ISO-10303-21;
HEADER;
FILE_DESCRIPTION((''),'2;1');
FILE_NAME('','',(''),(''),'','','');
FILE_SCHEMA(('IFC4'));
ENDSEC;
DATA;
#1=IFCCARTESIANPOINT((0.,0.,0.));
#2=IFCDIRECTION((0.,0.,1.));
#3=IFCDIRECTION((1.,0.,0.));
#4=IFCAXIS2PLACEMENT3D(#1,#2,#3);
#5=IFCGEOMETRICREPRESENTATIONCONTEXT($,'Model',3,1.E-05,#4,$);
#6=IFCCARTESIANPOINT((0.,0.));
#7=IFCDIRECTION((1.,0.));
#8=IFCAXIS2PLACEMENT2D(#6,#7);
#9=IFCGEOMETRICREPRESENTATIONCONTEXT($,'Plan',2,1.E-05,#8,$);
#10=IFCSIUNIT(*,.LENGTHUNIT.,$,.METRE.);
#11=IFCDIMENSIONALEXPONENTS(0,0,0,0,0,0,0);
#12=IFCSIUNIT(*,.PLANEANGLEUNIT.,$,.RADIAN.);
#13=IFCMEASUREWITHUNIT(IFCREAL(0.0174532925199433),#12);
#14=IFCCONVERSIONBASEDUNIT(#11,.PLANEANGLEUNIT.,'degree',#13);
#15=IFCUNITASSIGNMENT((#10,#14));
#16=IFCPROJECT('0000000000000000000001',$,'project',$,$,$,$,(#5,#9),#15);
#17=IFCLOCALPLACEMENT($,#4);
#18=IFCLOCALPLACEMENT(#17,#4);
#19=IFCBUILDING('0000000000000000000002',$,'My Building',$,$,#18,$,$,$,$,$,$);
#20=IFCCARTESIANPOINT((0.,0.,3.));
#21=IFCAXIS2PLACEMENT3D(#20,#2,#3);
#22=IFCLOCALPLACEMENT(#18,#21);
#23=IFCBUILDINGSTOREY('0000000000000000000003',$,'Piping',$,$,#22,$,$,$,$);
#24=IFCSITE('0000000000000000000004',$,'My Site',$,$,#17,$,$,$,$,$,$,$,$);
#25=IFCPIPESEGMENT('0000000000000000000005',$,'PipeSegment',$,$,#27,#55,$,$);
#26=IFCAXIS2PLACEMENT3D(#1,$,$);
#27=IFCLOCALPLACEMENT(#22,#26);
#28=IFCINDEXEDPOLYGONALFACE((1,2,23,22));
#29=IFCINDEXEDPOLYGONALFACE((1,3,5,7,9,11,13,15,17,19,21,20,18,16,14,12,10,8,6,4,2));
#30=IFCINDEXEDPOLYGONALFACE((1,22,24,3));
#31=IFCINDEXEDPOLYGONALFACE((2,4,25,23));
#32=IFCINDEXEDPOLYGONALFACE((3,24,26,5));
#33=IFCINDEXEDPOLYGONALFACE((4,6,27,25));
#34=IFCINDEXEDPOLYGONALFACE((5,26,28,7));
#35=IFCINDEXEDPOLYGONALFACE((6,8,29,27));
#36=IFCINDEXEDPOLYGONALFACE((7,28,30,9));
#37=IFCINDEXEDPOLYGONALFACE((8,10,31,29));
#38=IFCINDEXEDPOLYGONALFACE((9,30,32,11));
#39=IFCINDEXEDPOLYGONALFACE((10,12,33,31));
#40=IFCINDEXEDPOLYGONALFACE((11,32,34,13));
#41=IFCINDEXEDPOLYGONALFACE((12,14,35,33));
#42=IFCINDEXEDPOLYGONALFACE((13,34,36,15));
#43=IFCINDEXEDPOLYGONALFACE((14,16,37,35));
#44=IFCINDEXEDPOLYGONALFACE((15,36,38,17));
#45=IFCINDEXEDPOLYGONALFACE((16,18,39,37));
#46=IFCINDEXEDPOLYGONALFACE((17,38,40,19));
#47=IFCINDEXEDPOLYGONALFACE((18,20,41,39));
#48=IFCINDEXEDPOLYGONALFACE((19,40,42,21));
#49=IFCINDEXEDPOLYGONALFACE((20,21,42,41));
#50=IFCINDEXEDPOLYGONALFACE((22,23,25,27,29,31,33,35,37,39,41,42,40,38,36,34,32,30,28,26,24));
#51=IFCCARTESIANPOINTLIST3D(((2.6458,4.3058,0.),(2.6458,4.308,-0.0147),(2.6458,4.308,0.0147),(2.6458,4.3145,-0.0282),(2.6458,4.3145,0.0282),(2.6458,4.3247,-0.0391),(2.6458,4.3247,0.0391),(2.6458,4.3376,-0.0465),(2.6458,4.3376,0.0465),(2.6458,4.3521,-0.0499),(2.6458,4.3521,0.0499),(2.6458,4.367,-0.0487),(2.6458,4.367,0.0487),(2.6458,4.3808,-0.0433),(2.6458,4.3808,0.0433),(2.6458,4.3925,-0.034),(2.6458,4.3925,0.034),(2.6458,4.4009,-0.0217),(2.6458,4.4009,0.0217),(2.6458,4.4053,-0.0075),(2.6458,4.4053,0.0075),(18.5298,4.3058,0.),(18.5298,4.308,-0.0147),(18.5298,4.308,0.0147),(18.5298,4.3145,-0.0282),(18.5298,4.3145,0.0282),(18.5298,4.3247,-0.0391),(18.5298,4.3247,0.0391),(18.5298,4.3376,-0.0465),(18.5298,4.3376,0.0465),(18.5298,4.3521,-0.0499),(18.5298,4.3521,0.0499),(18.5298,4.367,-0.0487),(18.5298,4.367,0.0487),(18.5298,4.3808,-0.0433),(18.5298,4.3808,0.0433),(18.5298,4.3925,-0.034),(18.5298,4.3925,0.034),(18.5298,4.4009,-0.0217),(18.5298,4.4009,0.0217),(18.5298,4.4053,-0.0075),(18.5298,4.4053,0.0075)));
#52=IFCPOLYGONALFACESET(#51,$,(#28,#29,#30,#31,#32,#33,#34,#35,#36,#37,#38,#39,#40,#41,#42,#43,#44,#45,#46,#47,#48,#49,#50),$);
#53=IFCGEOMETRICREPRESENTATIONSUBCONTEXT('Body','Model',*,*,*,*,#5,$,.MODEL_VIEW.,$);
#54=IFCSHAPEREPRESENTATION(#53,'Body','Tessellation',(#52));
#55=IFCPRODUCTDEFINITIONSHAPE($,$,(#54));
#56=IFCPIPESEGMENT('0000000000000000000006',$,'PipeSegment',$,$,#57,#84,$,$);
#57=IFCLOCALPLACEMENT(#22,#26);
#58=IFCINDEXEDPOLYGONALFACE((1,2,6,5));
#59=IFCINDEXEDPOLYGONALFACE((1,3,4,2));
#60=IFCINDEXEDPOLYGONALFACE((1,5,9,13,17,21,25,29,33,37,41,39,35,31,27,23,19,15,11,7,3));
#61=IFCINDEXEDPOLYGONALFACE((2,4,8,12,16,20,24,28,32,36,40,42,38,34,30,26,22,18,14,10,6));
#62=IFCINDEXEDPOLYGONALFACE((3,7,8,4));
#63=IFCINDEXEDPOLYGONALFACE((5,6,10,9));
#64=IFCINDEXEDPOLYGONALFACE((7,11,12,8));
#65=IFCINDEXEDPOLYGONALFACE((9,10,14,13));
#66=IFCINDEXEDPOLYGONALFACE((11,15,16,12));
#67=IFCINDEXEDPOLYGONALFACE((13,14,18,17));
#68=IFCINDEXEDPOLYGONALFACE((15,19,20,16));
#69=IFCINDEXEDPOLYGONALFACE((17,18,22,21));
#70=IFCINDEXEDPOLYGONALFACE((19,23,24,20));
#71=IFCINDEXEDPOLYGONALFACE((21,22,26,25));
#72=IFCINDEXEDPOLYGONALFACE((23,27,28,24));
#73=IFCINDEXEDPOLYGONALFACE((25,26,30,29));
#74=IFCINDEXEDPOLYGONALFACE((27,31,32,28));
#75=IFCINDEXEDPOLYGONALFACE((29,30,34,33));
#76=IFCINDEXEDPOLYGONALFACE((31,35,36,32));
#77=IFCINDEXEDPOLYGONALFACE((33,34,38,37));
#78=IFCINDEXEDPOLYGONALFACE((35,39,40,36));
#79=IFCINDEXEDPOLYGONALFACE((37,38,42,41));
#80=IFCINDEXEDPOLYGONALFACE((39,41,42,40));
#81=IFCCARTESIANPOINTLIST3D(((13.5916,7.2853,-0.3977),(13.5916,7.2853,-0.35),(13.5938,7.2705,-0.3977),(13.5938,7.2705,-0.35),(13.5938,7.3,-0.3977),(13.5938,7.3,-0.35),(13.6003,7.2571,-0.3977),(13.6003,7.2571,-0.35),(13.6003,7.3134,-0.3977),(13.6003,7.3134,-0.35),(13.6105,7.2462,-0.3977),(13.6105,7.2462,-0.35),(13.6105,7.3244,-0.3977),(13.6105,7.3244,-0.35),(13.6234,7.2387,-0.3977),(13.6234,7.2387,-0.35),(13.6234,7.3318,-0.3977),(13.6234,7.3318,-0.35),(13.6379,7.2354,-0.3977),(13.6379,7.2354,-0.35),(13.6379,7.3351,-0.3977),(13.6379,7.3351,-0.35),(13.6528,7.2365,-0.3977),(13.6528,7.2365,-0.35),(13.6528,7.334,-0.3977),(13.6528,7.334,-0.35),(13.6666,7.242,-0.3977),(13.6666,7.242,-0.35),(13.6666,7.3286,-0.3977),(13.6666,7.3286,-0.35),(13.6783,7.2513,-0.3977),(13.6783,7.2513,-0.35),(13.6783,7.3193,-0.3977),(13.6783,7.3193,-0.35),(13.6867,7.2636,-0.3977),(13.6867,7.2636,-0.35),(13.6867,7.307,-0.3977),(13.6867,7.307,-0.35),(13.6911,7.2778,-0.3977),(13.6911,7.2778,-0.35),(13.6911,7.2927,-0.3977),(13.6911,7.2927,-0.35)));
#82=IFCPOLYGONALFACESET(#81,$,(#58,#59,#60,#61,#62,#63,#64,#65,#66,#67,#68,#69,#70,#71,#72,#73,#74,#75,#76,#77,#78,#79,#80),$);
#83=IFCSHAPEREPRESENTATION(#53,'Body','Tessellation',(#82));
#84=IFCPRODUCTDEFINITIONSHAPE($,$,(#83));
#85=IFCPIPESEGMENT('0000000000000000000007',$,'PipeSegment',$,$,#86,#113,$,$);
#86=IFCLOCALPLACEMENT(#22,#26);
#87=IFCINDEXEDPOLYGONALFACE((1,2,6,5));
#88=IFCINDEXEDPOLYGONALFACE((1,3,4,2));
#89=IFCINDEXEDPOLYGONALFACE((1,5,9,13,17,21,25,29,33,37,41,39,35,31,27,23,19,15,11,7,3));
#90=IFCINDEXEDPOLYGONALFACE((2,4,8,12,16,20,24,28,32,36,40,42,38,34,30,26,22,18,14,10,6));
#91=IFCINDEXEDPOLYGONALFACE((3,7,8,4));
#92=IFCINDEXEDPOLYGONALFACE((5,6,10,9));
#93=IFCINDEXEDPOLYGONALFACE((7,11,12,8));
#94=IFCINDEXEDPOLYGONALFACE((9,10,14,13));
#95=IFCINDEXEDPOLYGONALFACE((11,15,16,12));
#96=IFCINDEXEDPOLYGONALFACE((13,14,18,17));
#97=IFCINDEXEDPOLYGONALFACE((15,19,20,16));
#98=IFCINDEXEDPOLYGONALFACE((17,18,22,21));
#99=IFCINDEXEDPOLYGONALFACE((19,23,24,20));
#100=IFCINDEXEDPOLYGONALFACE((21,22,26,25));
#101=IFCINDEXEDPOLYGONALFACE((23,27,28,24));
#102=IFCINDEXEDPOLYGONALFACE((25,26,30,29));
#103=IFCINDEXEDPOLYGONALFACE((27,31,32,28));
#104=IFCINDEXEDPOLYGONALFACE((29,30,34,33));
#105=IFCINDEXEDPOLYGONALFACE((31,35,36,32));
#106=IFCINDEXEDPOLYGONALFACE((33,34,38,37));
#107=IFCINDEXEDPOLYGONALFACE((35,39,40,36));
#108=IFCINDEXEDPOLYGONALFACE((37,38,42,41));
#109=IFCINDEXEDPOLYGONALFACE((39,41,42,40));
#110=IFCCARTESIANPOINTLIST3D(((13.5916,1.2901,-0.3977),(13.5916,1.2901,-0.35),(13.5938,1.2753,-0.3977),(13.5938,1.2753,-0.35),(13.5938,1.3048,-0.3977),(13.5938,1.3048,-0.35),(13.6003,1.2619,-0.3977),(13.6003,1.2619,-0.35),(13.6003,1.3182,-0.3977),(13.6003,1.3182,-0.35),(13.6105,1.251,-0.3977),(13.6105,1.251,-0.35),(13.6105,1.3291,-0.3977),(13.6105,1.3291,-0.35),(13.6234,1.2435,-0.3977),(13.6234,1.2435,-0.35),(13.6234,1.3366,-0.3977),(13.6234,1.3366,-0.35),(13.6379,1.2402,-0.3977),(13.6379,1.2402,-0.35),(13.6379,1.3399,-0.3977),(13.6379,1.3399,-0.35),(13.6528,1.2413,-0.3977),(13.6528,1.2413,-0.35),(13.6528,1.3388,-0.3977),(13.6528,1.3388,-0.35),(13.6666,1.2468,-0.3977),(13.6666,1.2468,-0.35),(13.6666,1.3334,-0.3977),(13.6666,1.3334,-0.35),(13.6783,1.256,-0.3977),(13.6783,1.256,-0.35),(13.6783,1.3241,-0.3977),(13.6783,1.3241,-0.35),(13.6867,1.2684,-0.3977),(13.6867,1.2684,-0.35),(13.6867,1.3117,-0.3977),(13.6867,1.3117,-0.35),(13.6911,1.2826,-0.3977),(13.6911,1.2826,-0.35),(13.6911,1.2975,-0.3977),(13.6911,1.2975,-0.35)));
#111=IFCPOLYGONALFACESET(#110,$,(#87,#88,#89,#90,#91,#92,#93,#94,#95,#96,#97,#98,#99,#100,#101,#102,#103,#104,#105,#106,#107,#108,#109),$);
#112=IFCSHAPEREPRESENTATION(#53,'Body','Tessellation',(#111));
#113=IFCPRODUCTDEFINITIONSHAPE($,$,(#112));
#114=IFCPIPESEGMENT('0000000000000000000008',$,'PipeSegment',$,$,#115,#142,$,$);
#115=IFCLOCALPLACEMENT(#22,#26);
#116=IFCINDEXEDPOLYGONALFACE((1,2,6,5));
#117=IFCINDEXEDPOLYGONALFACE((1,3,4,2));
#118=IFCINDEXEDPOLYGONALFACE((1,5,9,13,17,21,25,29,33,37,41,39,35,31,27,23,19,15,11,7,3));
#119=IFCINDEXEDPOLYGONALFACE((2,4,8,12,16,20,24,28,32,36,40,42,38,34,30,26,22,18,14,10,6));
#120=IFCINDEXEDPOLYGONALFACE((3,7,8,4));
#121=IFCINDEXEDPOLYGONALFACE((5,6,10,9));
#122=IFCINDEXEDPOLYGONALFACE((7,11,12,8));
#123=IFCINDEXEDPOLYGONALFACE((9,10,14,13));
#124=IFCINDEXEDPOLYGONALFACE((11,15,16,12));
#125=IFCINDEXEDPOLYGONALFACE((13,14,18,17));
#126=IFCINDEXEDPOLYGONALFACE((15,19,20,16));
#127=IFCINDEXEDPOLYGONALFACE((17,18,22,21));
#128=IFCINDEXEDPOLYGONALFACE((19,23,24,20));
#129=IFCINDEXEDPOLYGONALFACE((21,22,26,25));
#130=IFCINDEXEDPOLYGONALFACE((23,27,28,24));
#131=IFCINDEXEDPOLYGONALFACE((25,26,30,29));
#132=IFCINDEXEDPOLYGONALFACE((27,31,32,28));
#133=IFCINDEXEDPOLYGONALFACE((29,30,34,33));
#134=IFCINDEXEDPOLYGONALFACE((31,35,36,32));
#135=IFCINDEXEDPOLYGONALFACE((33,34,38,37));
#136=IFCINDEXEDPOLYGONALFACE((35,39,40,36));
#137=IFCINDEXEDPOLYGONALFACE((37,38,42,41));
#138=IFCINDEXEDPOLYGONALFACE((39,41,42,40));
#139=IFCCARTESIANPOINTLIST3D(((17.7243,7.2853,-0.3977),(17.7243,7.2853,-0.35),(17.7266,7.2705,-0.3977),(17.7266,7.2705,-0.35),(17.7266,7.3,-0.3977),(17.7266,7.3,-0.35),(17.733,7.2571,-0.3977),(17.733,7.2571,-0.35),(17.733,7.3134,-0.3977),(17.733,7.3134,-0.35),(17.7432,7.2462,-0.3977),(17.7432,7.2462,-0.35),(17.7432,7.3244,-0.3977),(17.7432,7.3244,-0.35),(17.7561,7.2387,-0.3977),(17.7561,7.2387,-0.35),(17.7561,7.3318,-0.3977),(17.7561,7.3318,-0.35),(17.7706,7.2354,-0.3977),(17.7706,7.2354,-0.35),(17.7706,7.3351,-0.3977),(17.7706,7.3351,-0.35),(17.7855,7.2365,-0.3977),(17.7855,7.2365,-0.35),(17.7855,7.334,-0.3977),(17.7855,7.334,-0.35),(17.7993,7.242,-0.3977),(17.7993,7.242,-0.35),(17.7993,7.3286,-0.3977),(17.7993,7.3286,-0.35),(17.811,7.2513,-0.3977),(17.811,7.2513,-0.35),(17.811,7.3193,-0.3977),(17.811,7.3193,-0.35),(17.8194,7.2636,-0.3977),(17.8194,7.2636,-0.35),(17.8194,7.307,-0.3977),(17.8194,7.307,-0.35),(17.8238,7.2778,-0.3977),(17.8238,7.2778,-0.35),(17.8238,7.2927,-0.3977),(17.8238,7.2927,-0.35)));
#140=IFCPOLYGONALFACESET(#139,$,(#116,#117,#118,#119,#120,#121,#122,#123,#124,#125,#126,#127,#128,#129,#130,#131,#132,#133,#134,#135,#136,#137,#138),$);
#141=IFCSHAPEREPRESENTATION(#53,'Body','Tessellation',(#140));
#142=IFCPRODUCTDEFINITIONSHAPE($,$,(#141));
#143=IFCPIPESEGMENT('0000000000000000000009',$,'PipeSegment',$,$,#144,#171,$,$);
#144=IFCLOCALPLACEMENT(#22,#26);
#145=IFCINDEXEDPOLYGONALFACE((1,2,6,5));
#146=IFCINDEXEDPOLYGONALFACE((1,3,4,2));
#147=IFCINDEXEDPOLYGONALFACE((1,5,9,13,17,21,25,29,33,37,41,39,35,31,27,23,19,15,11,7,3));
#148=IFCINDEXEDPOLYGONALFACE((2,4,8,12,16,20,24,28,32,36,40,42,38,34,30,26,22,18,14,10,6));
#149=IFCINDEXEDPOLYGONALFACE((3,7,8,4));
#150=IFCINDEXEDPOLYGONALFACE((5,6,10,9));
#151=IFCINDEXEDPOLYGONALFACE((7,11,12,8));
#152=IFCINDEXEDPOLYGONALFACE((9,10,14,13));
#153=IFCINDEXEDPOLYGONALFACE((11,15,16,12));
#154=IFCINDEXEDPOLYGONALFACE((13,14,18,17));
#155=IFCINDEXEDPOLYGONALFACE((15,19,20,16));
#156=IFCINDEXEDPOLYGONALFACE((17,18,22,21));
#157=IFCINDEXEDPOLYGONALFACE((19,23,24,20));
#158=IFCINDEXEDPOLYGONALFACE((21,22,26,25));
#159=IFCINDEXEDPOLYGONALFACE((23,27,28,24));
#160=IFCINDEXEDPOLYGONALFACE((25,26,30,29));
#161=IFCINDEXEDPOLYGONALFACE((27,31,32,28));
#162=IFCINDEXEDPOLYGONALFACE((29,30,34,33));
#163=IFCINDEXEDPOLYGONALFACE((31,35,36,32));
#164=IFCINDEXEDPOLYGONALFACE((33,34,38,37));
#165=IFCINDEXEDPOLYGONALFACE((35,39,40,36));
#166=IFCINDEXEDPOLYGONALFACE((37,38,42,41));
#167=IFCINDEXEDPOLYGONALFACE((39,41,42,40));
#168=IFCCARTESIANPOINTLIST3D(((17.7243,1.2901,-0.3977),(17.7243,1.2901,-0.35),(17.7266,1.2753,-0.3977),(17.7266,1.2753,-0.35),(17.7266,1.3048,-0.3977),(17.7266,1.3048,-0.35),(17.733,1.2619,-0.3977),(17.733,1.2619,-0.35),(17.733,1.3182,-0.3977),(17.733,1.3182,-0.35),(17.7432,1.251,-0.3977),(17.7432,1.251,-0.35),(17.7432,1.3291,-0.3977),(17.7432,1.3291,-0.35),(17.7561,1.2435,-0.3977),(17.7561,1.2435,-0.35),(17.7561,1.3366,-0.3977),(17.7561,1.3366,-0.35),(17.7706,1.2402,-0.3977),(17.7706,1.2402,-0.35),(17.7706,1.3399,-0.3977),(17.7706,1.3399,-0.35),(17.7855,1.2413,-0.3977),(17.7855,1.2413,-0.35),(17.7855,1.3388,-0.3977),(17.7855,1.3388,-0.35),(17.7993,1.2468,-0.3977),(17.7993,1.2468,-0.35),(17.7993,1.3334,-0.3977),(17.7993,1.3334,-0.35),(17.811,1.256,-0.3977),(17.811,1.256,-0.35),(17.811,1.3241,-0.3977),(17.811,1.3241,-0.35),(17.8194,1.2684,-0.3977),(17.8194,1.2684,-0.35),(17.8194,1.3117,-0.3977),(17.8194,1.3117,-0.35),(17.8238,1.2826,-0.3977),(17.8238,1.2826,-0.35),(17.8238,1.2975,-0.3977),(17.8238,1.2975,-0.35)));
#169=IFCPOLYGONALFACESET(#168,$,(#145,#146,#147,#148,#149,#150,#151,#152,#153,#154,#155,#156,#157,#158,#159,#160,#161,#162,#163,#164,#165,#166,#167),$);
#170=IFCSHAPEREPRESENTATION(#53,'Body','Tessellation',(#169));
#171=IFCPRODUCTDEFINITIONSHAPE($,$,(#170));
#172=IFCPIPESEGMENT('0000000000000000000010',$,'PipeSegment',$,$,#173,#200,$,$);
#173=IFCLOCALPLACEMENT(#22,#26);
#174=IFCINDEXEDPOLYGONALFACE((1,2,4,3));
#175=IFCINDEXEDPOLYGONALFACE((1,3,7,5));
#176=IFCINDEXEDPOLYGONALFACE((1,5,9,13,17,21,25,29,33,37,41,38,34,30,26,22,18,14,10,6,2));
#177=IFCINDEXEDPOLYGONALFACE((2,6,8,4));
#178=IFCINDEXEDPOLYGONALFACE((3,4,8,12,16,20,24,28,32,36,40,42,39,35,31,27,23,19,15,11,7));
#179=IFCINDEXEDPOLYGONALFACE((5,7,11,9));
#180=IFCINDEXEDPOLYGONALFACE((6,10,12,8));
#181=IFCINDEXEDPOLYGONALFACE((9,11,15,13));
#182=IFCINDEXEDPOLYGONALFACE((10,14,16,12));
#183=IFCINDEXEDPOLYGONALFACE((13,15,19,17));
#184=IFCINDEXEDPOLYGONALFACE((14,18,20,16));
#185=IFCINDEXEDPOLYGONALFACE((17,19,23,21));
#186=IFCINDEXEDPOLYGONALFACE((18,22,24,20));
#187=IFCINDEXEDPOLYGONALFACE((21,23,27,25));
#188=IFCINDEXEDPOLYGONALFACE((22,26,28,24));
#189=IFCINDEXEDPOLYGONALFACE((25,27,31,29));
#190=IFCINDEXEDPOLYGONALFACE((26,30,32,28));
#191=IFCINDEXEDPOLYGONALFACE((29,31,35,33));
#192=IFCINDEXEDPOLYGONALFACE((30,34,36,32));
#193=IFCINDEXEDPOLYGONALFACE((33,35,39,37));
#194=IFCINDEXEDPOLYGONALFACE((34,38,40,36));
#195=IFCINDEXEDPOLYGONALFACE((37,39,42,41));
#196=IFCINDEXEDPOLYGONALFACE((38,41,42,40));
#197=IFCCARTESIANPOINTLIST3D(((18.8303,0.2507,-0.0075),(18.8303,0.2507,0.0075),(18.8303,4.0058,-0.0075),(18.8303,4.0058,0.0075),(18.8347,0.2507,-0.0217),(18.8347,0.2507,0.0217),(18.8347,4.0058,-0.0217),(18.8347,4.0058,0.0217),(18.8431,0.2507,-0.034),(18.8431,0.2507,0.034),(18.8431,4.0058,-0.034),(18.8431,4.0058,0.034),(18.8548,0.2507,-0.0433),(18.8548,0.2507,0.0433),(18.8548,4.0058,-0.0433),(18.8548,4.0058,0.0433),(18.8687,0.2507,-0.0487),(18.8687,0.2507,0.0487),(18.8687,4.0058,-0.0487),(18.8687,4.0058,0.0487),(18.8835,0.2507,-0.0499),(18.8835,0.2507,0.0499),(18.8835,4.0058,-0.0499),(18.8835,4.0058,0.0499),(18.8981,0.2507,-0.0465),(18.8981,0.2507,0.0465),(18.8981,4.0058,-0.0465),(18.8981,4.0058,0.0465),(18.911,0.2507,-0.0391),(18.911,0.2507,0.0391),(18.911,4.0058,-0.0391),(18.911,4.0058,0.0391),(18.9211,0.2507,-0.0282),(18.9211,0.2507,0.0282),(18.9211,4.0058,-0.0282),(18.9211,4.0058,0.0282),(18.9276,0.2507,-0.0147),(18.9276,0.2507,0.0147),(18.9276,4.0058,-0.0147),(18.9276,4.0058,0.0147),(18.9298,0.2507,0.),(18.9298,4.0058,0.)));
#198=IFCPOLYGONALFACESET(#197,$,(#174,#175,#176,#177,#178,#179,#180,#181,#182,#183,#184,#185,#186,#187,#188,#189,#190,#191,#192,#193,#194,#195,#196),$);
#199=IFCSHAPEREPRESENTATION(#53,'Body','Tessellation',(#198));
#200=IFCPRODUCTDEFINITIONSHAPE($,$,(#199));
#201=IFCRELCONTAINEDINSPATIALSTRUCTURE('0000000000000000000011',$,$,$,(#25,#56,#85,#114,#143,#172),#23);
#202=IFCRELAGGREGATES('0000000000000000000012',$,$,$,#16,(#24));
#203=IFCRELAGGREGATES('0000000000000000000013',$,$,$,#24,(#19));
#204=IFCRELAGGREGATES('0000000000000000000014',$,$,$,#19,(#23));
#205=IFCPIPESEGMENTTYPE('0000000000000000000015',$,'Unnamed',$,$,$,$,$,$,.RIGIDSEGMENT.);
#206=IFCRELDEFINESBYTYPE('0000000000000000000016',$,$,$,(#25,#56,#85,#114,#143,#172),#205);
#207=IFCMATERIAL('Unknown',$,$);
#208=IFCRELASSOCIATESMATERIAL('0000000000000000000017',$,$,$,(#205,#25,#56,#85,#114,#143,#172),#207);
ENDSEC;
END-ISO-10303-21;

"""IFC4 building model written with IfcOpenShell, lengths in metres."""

from ifc_helpers import new_model, entity, si_unit, converted_unit, frame, origin_with_axes, origin_2d_with_axis, place, context, subcontext, project, spatial, circle, extrude, material, material_profile, profile_set, profile_usage, type_object, element, save


model = new_model("IFC4")

# Units and contexts
model_context = context("Model", 3, precision=1e-05, world=origin_with_axes())
plan_context = context("Plan", 2, precision=1e-05, world=origin_2d_with_axis())
body_context = subcontext(model_context, "Body", "Model", "MODEL_VIEW")
ifc_project = project(units=[si_unit("LENGTHUNIT", "METRE"), converted_unit("PLANEANGLEUNIT", "degree", entity("IfcReal", 0.0174532925199433), si_unit("PLANEANGLEUNIT", "RADIAN"), dimensions=[0, 0, 0, 0, 0, 0, 0])], contexts=[model_context, plan_context])

# Site, building, storey
site_placement = place(None, origin_with_axes())
site = spatial("IfcSite", under=ifc_project, at=site_placement, Name="My Site")
building_placement = place(site_placement, origin_with_axes())
building = spatial("IfcBuilding", under=site, at=building_placement, Name="My Building")
storey_placement = place(building_placement, frame((0.0, 0.0, 3.0), z_axis=(0.0, 0.0, 1.0), x_axis=(1.0, 0.0, 0.0)))
storey = spatial("IfcBuildingStorey", under=building, at=storey_placement, Name="Piping")

# Pipe segments
ifc_material = material(Name="Unknown")
ifc_material_profile_1 = material_profile(ifc_material, circle(Radius=0.05))
ifc_profile_set_1 = profile_set([ifc_material_profile_1])
ifc_profile_usage_1 = profile_usage(ifc_profile_set_1, cardinal=5)
pipe_segment_type = type_object("IfcPipeSegmentType", Name="Unnamed", PredefinedType="RIGIDSEGMENT", material=ifc_profile_set_1)
pipe_segment_1_placement = place(storey_placement, frame((18.5298, 4.3558, 0.0), z_axis=(-1.0, 0.0, 0.0), x_axis=(0.0, -1.0, 0.0)))
element("IfcPipeSegment", 1, at=pipe_segment_1_placement, inside=storey, type_object=pipe_segment_type, material=ifc_profile_usage_1, Name="PipeSegment", context=body_context, shape_type="SweptSolid", body=[
    extrude(circle(Radius=0.05), origin_with_axes(), (0.0, 0.0, 1.0), 15.884),
])
ifc_profile_usage_2 = profile_usage(ifc_profile_set_1, cardinal=5)
pipe_segment_2_placement = place(storey_placement, frame((13.6416, 7.2853, -0.35), z_axis=(0.0, 0.0, -1.0), x_axis=(-1.0, 0.0, 0.0)))
element("IfcPipeSegment", 2, at=pipe_segment_2_placement, inside=storey, type_object=pipe_segment_type, material=ifc_profile_usage_2, Name="PipeSegment", context=body_context, shape_type="SweptSolid", body=[
    extrude(circle(Radius=0.05), origin_with_axes(), (0.0, 0.0, 1.0), 0.0477),
])
ifc_profile_usage_3 = profile_usage(ifc_profile_set_1, cardinal=5)
pipe_segment_3_placement = place(storey_placement, frame((13.6416, 1.2901, -0.35), z_axis=(0.0, 0.0, -1.0), x_axis=(-1.0, 0.0, 0.0)))
element("IfcPipeSegment", 3, at=pipe_segment_3_placement, inside=storey, type_object=pipe_segment_type, material=ifc_profile_usage_3, Name="PipeSegment", context=body_context, shape_type="SweptSolid", body=[
    extrude(circle(Radius=0.05), origin_with_axes(), (0.0, 0.0, 1.0), 0.0477),
])
ifc_profile_usage_4 = profile_usage(ifc_profile_set_1, cardinal=5)
pipe_segment_4_placement = place(storey_placement, frame((17.7743, 7.2853, -0.35), z_axis=(0.0, 0.0, -1.0), x_axis=(-1.0, 0.0, 0.0)))
element("IfcPipeSegment", 4, at=pipe_segment_4_placement, inside=storey, type_object=pipe_segment_type, material=ifc_profile_usage_4, Name="PipeSegment", context=body_context, shape_type="SweptSolid", body=[
    extrude(circle(Radius=0.05), origin_with_axes(), (0.0, 0.0, 1.0), 0.0477),
])
ifc_profile_usage_5 = profile_usage(ifc_profile_set_1, cardinal=5)
pipe_segment_5_placement = place(storey_placement, frame((17.7743, 1.2901, -0.35), z_axis=(0.0, 0.0, -1.0), x_axis=(-1.0, 0.0, 0.0)))
element("IfcPipeSegment", 5, at=pipe_segment_5_placement, inside=storey, type_object=pipe_segment_type, material=ifc_profile_usage_5, Name="PipeSegment", context=body_context, shape_type="SweptSolid", body=[
    extrude(circle(Radius=0.05), origin_with_axes(), (0.0, 0.0, 1.0), 0.0477),
])
ifc_profile_usage_6 = profile_usage(ifc_profile_set_1, cardinal=5)
pipe_segment_6_placement = place(storey_placement, frame((18.8798, 4.0058, 0.0), z_axis=(0.0, -1.0, 0.0), x_axis=(1.0, 0.0, 0.0)))
element("IfcPipeSegment", 6, at=pipe_segment_6_placement, inside=storey, type_object=pipe_segment_type, material=ifc_profile_usage_6, Name="PipeSegment", context=body_context, shape_type="SweptSolid", body=[
    extrude(circle(Radius=0.05), origin_with_axes(), (0.0, 0.0, 1.0), 3.7551),
])

save(model, "model.ifc")
